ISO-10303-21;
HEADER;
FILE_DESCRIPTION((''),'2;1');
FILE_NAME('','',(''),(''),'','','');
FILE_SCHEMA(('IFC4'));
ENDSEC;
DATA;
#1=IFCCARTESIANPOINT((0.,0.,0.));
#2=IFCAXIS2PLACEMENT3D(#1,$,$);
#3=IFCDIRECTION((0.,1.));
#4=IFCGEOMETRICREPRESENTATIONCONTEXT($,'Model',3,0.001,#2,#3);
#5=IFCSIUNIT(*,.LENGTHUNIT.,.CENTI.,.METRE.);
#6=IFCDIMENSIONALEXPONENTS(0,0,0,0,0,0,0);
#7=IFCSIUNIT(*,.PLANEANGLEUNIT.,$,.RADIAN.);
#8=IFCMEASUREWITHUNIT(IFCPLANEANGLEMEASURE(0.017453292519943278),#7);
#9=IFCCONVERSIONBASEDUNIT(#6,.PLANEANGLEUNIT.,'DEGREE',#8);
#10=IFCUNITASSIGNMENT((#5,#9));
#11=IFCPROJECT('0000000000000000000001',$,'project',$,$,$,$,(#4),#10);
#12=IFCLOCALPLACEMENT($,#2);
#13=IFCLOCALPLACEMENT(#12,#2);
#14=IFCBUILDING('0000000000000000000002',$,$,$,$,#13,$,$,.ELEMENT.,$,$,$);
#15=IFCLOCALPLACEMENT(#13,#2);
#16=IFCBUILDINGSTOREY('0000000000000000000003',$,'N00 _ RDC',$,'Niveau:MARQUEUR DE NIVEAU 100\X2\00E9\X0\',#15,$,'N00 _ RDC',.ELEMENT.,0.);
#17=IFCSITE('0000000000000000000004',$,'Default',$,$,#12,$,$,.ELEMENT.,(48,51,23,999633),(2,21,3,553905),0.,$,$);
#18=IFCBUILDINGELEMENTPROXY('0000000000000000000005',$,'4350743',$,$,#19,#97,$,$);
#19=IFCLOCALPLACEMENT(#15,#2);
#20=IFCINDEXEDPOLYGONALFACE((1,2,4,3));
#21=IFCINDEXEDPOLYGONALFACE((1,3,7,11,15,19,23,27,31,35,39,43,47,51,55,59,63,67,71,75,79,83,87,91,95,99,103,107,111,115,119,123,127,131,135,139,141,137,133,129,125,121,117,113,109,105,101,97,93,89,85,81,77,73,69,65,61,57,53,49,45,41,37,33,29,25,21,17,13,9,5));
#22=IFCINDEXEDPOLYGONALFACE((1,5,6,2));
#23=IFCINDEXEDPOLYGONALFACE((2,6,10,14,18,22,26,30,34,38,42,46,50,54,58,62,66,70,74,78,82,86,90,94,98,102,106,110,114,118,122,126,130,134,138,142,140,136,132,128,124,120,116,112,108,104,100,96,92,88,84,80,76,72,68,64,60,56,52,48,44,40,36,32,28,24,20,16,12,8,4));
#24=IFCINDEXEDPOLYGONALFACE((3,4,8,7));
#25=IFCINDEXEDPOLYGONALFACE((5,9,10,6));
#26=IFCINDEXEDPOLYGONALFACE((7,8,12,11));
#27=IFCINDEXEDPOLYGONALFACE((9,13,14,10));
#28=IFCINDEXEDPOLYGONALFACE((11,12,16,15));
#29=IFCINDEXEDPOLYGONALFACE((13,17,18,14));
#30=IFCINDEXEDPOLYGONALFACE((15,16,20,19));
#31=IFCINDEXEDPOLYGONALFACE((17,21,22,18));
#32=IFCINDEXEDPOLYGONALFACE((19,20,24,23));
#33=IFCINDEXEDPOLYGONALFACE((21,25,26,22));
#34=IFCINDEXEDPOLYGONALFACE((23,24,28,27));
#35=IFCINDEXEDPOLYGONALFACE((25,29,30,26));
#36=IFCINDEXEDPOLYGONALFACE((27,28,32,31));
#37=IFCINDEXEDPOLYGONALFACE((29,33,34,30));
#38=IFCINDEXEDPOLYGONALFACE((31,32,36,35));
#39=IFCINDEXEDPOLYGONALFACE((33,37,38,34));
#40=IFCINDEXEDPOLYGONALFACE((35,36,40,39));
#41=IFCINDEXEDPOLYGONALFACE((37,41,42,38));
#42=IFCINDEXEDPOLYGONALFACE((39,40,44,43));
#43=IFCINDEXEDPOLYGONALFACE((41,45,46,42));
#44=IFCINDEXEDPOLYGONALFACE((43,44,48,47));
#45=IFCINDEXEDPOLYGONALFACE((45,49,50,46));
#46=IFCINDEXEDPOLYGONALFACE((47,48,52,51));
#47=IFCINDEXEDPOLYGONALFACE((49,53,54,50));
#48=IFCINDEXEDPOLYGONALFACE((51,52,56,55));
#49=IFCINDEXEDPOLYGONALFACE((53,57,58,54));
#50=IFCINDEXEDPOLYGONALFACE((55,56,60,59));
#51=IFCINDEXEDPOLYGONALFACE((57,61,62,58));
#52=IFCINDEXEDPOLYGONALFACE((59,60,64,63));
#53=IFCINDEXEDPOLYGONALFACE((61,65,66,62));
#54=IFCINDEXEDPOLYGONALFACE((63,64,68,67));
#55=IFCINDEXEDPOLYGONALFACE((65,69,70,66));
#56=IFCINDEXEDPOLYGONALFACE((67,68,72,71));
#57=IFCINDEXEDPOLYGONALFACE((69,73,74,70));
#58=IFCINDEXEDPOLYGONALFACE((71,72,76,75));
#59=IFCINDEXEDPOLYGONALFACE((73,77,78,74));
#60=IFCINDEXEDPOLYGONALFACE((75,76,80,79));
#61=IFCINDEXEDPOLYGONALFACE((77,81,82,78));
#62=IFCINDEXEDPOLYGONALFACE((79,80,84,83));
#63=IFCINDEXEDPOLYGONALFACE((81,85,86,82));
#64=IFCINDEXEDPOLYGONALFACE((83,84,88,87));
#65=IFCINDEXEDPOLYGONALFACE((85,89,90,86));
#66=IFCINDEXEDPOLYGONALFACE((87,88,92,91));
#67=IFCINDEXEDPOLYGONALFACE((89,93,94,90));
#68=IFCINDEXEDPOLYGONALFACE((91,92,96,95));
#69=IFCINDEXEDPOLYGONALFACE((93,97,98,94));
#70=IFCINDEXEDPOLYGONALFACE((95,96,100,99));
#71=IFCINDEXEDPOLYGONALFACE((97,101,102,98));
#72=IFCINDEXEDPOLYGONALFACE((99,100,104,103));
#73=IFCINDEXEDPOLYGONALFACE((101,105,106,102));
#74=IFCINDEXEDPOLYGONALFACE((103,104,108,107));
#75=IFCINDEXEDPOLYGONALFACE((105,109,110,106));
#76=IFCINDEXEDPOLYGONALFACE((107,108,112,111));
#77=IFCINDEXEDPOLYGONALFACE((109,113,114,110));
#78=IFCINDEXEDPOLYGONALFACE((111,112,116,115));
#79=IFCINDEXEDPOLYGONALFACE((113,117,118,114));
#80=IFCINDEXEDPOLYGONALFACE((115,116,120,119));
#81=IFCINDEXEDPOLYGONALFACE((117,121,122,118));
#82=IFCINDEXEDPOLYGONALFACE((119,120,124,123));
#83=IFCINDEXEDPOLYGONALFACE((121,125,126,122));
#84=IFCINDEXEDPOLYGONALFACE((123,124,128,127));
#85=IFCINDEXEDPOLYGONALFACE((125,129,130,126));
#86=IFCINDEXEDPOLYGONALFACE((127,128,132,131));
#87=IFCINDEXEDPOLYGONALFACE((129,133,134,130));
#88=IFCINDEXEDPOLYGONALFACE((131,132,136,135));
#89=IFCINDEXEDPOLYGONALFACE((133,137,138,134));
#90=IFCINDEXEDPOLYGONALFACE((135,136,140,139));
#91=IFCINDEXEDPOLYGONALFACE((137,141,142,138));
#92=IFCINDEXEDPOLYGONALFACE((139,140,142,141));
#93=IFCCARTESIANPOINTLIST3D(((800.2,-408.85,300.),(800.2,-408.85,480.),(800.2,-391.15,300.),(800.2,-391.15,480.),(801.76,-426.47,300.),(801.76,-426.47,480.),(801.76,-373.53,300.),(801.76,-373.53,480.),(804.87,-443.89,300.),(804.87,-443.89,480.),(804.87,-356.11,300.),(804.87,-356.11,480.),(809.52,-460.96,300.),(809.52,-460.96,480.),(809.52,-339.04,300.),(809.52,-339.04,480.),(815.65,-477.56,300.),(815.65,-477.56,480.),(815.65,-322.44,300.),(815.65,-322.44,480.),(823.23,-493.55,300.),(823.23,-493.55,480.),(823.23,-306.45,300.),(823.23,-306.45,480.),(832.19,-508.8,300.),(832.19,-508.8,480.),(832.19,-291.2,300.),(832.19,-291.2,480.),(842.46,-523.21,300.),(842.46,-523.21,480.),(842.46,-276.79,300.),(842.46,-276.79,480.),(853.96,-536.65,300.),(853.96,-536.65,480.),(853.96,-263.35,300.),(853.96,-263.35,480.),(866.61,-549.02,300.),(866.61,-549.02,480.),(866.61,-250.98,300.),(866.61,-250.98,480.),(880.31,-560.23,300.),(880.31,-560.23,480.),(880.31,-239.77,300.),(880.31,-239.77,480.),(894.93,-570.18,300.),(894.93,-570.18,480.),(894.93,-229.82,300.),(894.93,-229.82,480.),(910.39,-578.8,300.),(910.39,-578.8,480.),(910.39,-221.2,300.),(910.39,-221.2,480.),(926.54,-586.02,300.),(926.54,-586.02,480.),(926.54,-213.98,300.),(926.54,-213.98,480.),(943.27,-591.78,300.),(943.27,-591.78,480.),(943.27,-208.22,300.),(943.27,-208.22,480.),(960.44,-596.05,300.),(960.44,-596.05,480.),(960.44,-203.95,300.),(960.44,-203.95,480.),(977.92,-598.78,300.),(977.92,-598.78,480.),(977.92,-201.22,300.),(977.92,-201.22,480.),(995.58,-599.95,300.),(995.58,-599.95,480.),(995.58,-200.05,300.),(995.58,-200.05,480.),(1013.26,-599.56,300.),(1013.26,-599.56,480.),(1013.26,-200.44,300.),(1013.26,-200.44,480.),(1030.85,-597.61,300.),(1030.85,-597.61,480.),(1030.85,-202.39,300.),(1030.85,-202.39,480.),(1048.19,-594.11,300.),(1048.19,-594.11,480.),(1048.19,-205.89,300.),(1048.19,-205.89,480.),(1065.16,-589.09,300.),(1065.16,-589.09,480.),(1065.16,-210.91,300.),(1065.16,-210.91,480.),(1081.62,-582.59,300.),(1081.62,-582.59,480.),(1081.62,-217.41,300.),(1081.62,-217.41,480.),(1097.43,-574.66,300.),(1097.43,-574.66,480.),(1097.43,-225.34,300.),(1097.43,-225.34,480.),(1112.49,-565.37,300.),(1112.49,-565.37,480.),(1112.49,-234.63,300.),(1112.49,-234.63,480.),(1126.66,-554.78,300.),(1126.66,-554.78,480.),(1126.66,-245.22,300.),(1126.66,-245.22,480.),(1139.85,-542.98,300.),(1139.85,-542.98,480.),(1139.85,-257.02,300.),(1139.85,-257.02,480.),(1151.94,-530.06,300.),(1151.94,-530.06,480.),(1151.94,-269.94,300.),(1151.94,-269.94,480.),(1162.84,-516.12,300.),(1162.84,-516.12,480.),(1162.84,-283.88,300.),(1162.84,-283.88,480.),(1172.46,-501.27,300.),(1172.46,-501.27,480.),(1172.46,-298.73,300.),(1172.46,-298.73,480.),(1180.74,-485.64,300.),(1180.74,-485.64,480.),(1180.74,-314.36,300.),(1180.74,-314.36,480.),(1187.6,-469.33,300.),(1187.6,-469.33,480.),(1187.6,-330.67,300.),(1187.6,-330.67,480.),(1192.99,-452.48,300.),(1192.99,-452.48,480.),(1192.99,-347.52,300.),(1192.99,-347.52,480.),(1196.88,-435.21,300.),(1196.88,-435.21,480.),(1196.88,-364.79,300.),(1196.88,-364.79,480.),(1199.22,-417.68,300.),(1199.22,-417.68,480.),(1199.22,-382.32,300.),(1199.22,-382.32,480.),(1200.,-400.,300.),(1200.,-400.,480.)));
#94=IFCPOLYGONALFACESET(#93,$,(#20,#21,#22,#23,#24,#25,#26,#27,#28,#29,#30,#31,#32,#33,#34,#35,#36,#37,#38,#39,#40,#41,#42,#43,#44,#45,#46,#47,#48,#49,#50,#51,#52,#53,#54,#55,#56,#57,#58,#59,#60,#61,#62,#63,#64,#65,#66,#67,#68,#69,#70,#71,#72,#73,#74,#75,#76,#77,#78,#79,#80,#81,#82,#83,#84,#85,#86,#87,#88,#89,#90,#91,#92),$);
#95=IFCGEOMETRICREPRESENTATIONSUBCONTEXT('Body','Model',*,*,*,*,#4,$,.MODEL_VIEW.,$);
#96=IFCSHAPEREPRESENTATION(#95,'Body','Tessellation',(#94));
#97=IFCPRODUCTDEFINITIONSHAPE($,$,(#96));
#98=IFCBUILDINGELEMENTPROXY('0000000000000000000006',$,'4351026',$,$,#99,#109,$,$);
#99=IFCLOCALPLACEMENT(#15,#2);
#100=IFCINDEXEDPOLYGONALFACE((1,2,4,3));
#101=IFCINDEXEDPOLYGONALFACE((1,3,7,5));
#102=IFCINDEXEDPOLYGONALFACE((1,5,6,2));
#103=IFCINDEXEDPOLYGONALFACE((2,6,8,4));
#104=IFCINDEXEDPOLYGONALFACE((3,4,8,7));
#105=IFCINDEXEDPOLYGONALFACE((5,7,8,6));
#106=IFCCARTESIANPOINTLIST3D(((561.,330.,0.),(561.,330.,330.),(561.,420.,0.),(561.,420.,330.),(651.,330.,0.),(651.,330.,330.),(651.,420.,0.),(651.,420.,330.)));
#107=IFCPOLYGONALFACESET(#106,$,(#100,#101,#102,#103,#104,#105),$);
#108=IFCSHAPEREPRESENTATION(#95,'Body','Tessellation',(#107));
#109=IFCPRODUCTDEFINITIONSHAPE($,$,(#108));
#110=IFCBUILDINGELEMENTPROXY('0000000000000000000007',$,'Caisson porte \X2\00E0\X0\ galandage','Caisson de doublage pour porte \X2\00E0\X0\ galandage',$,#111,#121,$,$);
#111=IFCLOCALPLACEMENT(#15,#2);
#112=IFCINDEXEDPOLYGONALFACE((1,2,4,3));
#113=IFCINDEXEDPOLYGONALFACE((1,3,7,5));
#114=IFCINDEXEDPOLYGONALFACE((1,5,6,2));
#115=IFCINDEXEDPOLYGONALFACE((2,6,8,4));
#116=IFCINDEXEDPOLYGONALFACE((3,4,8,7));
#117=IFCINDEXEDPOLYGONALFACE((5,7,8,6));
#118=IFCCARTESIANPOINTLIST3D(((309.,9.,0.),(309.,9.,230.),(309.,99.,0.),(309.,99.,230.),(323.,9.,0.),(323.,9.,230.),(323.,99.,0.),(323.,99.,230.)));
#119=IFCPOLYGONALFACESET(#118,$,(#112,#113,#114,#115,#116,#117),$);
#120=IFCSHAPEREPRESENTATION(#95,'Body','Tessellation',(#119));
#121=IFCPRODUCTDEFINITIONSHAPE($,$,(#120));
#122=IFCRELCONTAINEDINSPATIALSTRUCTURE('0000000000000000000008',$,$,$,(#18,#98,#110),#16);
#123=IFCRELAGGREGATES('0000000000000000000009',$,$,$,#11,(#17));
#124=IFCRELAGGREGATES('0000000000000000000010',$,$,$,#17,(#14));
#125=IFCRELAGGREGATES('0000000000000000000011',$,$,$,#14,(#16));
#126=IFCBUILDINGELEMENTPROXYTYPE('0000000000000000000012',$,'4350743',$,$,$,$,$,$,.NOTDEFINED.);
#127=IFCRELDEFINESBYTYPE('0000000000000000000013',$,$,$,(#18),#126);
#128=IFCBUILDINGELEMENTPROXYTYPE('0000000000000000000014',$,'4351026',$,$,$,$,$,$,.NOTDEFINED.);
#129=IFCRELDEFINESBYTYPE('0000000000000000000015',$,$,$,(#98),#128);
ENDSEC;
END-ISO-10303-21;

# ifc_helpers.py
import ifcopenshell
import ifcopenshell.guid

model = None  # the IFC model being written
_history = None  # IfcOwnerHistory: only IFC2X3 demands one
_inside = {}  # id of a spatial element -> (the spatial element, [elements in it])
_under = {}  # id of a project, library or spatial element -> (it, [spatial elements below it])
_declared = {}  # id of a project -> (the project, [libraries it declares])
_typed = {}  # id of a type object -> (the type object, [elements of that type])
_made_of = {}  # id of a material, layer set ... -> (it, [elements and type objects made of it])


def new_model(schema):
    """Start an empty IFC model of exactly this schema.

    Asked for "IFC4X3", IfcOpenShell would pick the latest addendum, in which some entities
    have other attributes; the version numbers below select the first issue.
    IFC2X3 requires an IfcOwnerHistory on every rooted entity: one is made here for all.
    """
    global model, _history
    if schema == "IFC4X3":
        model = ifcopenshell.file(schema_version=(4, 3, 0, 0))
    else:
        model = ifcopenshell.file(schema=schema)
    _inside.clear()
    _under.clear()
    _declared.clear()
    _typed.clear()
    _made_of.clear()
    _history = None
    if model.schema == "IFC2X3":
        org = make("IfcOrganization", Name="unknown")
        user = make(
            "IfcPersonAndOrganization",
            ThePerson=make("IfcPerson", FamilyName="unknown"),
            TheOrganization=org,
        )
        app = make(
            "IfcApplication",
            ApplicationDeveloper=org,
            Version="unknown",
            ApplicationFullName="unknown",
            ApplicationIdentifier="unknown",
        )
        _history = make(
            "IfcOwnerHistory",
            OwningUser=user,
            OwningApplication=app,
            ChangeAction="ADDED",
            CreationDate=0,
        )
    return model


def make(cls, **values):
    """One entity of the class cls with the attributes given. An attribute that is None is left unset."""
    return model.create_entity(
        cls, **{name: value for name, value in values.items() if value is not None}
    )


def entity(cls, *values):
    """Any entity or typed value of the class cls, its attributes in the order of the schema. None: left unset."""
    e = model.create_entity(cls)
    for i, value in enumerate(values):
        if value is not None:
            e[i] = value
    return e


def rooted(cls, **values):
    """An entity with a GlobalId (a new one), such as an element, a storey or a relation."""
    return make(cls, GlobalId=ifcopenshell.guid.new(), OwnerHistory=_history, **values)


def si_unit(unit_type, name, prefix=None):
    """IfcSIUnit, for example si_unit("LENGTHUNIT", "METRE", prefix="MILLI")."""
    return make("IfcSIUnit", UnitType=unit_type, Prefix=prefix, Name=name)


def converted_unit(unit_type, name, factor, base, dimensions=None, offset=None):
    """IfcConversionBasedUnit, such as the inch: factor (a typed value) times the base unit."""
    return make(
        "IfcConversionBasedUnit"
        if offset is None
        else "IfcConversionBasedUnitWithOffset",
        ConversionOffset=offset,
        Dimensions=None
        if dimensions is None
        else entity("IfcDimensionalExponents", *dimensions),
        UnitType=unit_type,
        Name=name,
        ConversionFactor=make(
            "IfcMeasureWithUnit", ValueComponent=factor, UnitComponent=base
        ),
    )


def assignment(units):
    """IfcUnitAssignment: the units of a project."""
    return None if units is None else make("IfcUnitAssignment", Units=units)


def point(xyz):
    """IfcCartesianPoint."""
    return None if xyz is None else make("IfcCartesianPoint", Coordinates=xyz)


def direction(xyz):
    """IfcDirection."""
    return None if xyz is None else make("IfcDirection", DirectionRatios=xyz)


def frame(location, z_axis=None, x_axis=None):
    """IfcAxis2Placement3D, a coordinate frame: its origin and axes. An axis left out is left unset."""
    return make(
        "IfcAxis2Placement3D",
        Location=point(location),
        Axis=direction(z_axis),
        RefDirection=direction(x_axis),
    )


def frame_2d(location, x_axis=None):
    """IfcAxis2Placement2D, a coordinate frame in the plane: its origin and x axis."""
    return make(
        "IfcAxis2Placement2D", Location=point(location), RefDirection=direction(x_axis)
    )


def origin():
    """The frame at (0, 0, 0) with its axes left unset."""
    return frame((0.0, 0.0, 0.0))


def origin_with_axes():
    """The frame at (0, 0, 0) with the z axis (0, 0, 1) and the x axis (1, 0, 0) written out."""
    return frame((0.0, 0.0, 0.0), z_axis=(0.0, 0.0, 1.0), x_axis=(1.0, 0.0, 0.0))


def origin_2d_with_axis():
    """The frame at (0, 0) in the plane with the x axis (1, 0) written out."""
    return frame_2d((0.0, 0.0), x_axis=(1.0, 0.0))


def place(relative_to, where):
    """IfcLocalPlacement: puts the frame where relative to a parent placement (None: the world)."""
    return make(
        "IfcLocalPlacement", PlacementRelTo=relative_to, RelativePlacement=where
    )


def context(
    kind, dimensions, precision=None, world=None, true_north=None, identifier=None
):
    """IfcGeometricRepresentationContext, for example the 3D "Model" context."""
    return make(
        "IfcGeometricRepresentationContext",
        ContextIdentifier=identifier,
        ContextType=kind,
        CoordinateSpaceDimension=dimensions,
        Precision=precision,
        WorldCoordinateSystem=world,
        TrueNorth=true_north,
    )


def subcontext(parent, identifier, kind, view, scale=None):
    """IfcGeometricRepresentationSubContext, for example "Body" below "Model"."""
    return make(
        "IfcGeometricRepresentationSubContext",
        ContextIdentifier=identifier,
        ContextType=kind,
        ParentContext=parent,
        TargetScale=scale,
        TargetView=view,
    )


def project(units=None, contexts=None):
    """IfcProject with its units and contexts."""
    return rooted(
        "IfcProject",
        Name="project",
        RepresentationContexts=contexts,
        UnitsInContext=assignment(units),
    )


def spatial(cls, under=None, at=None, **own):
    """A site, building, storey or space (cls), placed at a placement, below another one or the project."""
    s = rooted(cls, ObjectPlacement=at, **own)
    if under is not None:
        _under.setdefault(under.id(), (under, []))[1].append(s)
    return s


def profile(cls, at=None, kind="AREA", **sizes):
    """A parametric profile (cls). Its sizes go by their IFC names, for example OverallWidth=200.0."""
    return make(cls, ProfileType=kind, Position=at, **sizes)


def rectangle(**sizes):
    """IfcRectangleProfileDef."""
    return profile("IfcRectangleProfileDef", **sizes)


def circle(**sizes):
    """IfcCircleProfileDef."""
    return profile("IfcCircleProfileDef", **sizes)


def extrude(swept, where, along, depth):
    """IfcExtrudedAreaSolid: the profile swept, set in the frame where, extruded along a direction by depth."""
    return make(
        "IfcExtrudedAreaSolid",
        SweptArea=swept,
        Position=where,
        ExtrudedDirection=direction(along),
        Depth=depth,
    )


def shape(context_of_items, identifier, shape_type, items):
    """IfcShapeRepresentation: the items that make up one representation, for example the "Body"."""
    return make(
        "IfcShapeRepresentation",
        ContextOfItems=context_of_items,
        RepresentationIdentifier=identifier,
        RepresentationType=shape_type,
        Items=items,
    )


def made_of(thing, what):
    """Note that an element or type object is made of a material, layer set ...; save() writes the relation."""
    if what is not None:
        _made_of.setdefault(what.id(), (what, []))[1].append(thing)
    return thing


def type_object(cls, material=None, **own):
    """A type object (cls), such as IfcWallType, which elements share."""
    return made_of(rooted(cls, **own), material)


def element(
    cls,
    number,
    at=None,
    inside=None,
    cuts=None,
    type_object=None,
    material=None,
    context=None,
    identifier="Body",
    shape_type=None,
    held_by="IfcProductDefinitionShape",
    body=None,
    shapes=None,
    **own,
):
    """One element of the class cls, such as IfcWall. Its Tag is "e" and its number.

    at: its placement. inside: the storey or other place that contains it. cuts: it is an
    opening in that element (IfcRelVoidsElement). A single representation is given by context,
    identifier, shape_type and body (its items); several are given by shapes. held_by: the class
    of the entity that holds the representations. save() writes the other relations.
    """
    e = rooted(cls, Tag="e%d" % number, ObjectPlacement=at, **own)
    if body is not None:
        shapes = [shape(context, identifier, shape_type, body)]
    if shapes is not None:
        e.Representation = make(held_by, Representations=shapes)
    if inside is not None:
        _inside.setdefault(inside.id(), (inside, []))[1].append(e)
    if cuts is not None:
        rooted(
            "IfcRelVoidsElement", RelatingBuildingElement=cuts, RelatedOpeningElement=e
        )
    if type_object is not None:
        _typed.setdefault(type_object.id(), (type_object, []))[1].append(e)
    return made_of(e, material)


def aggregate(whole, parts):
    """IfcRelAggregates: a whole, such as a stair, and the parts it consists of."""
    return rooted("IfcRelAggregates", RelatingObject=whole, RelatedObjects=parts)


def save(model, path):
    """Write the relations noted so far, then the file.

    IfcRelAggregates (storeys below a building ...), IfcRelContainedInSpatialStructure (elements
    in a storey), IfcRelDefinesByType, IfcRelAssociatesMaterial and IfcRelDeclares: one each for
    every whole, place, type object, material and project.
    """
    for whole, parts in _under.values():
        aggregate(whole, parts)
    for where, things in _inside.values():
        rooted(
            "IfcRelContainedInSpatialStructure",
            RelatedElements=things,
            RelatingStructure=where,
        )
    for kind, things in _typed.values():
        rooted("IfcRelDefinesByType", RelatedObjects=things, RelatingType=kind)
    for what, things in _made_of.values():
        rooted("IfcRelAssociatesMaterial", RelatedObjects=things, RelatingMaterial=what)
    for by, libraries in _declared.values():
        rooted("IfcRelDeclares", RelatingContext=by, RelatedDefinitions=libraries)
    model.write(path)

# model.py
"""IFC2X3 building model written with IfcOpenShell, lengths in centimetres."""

from ifc_helpers import new_model, entity, si_unit, converted_unit, direction, frame, frame_2d, origin, origin_with_axes, origin_2d_with_axis, place, context, subcontext, project, spatial, rectangle, circle, extrude, type_object, element, save


model = new_model("IFC2X3")

# Units and contexts
model_context = context("Model", 3, precision=0.001, world=origin(), true_north=direction((0.0, 1.0)))
body_context = subcontext(model_context, "Body", "Model", "MODEL_VIEW")
ifc_project = project(units=[si_unit("LENGTHUNIT", "METRE", prefix="CENTI"), converted_unit("PLANEANGLEUNIT", "DEGREE", entity("IfcPlaneAngleMeasure", 0.017453292519943278), si_unit("PLANEANGLEUNIT", "RADIAN"), dimensions=[0, 0, 0, 0, 0, 0, 0])], contexts=[model_context])

# Site, building, storey
site_placement = place(None, origin())
site = spatial("IfcSite", under=ifc_project, at=site_placement, Name="Default", CompositionType="ELEMENT", RefLatitude=(48, 51, 23, 999633), RefLongitude=(2, 21, 3, 553905), RefElevation=0.0)
building_placement = place(site_placement, origin())
building = spatial("IfcBuilding", under=site, at=building_placement, CompositionType="ELEMENT")
storey_placement = place(building_placement, origin())
storey = spatial("IfcBuildingStorey", under=building, at=storey_placement, Name="N00 _ RDC", ObjectType="Niveau:MARQUEUR DE NIVEAU 100é", LongName="N00 _ RDC", CompositionType="ELEMENT", Elevation=0.0)

# Building element proxies
building_element_proxy_type_1 = type_object("IfcBuildingElementProxyType", Name="4350743", PredefinedType="NOTDEFINED")
proxy_1_placement = place(storey_placement, origin())
element("IfcBuildingElementProxy", 1, at=proxy_1_placement, inside=storey, type_object=building_element_proxy_type_1, Name="4350743", context=body_context, shape_type="SweptSolid", body=[
    extrude(circle(Radius=200.0, at=origin_2d_with_axis()), frame((1000.0, -400.0, 300.0)), (0.0, 0.0, 1.0), 180.0),
])
building_element_proxy_type_2 = type_object("IfcBuildingElementProxyType", Name="4351026", PredefinedType="NOTDEFINED")
proxy_2_placement = place(storey_placement, origin())
element("IfcBuildingElementProxy", 2, at=proxy_2_placement, inside=storey, type_object=building_element_proxy_type_2, Name="4351026", context=body_context, shape_type="SweptSolid", body=[
    extrude(rectangle(XDim=90.0, YDim=90.0, at=frame_2d((0.0, 0.0), x_axis=(1.0, 0.0))), frame((606.0, 375.0, 0.0)), (0.0, 0.0, 1.0), 330.0),
])
proxy_3_placement = place(storey_placement, origin_with_axes())
element("IfcBuildingElementProxy", 3, at=proxy_3_placement, inside=storey, Name="Caisson porte à galandage", Description="Caisson de doublage pour porte à galandage", context=body_context, shape_type="SweptSolid", body=[
    extrude(rectangle(XDim=14.0, YDim=90.0, at=frame_2d((316.0, 54.0))), origin(), (0.0, 0.0, 1.0), 230.0),
])

save(model, "model.ifc")
